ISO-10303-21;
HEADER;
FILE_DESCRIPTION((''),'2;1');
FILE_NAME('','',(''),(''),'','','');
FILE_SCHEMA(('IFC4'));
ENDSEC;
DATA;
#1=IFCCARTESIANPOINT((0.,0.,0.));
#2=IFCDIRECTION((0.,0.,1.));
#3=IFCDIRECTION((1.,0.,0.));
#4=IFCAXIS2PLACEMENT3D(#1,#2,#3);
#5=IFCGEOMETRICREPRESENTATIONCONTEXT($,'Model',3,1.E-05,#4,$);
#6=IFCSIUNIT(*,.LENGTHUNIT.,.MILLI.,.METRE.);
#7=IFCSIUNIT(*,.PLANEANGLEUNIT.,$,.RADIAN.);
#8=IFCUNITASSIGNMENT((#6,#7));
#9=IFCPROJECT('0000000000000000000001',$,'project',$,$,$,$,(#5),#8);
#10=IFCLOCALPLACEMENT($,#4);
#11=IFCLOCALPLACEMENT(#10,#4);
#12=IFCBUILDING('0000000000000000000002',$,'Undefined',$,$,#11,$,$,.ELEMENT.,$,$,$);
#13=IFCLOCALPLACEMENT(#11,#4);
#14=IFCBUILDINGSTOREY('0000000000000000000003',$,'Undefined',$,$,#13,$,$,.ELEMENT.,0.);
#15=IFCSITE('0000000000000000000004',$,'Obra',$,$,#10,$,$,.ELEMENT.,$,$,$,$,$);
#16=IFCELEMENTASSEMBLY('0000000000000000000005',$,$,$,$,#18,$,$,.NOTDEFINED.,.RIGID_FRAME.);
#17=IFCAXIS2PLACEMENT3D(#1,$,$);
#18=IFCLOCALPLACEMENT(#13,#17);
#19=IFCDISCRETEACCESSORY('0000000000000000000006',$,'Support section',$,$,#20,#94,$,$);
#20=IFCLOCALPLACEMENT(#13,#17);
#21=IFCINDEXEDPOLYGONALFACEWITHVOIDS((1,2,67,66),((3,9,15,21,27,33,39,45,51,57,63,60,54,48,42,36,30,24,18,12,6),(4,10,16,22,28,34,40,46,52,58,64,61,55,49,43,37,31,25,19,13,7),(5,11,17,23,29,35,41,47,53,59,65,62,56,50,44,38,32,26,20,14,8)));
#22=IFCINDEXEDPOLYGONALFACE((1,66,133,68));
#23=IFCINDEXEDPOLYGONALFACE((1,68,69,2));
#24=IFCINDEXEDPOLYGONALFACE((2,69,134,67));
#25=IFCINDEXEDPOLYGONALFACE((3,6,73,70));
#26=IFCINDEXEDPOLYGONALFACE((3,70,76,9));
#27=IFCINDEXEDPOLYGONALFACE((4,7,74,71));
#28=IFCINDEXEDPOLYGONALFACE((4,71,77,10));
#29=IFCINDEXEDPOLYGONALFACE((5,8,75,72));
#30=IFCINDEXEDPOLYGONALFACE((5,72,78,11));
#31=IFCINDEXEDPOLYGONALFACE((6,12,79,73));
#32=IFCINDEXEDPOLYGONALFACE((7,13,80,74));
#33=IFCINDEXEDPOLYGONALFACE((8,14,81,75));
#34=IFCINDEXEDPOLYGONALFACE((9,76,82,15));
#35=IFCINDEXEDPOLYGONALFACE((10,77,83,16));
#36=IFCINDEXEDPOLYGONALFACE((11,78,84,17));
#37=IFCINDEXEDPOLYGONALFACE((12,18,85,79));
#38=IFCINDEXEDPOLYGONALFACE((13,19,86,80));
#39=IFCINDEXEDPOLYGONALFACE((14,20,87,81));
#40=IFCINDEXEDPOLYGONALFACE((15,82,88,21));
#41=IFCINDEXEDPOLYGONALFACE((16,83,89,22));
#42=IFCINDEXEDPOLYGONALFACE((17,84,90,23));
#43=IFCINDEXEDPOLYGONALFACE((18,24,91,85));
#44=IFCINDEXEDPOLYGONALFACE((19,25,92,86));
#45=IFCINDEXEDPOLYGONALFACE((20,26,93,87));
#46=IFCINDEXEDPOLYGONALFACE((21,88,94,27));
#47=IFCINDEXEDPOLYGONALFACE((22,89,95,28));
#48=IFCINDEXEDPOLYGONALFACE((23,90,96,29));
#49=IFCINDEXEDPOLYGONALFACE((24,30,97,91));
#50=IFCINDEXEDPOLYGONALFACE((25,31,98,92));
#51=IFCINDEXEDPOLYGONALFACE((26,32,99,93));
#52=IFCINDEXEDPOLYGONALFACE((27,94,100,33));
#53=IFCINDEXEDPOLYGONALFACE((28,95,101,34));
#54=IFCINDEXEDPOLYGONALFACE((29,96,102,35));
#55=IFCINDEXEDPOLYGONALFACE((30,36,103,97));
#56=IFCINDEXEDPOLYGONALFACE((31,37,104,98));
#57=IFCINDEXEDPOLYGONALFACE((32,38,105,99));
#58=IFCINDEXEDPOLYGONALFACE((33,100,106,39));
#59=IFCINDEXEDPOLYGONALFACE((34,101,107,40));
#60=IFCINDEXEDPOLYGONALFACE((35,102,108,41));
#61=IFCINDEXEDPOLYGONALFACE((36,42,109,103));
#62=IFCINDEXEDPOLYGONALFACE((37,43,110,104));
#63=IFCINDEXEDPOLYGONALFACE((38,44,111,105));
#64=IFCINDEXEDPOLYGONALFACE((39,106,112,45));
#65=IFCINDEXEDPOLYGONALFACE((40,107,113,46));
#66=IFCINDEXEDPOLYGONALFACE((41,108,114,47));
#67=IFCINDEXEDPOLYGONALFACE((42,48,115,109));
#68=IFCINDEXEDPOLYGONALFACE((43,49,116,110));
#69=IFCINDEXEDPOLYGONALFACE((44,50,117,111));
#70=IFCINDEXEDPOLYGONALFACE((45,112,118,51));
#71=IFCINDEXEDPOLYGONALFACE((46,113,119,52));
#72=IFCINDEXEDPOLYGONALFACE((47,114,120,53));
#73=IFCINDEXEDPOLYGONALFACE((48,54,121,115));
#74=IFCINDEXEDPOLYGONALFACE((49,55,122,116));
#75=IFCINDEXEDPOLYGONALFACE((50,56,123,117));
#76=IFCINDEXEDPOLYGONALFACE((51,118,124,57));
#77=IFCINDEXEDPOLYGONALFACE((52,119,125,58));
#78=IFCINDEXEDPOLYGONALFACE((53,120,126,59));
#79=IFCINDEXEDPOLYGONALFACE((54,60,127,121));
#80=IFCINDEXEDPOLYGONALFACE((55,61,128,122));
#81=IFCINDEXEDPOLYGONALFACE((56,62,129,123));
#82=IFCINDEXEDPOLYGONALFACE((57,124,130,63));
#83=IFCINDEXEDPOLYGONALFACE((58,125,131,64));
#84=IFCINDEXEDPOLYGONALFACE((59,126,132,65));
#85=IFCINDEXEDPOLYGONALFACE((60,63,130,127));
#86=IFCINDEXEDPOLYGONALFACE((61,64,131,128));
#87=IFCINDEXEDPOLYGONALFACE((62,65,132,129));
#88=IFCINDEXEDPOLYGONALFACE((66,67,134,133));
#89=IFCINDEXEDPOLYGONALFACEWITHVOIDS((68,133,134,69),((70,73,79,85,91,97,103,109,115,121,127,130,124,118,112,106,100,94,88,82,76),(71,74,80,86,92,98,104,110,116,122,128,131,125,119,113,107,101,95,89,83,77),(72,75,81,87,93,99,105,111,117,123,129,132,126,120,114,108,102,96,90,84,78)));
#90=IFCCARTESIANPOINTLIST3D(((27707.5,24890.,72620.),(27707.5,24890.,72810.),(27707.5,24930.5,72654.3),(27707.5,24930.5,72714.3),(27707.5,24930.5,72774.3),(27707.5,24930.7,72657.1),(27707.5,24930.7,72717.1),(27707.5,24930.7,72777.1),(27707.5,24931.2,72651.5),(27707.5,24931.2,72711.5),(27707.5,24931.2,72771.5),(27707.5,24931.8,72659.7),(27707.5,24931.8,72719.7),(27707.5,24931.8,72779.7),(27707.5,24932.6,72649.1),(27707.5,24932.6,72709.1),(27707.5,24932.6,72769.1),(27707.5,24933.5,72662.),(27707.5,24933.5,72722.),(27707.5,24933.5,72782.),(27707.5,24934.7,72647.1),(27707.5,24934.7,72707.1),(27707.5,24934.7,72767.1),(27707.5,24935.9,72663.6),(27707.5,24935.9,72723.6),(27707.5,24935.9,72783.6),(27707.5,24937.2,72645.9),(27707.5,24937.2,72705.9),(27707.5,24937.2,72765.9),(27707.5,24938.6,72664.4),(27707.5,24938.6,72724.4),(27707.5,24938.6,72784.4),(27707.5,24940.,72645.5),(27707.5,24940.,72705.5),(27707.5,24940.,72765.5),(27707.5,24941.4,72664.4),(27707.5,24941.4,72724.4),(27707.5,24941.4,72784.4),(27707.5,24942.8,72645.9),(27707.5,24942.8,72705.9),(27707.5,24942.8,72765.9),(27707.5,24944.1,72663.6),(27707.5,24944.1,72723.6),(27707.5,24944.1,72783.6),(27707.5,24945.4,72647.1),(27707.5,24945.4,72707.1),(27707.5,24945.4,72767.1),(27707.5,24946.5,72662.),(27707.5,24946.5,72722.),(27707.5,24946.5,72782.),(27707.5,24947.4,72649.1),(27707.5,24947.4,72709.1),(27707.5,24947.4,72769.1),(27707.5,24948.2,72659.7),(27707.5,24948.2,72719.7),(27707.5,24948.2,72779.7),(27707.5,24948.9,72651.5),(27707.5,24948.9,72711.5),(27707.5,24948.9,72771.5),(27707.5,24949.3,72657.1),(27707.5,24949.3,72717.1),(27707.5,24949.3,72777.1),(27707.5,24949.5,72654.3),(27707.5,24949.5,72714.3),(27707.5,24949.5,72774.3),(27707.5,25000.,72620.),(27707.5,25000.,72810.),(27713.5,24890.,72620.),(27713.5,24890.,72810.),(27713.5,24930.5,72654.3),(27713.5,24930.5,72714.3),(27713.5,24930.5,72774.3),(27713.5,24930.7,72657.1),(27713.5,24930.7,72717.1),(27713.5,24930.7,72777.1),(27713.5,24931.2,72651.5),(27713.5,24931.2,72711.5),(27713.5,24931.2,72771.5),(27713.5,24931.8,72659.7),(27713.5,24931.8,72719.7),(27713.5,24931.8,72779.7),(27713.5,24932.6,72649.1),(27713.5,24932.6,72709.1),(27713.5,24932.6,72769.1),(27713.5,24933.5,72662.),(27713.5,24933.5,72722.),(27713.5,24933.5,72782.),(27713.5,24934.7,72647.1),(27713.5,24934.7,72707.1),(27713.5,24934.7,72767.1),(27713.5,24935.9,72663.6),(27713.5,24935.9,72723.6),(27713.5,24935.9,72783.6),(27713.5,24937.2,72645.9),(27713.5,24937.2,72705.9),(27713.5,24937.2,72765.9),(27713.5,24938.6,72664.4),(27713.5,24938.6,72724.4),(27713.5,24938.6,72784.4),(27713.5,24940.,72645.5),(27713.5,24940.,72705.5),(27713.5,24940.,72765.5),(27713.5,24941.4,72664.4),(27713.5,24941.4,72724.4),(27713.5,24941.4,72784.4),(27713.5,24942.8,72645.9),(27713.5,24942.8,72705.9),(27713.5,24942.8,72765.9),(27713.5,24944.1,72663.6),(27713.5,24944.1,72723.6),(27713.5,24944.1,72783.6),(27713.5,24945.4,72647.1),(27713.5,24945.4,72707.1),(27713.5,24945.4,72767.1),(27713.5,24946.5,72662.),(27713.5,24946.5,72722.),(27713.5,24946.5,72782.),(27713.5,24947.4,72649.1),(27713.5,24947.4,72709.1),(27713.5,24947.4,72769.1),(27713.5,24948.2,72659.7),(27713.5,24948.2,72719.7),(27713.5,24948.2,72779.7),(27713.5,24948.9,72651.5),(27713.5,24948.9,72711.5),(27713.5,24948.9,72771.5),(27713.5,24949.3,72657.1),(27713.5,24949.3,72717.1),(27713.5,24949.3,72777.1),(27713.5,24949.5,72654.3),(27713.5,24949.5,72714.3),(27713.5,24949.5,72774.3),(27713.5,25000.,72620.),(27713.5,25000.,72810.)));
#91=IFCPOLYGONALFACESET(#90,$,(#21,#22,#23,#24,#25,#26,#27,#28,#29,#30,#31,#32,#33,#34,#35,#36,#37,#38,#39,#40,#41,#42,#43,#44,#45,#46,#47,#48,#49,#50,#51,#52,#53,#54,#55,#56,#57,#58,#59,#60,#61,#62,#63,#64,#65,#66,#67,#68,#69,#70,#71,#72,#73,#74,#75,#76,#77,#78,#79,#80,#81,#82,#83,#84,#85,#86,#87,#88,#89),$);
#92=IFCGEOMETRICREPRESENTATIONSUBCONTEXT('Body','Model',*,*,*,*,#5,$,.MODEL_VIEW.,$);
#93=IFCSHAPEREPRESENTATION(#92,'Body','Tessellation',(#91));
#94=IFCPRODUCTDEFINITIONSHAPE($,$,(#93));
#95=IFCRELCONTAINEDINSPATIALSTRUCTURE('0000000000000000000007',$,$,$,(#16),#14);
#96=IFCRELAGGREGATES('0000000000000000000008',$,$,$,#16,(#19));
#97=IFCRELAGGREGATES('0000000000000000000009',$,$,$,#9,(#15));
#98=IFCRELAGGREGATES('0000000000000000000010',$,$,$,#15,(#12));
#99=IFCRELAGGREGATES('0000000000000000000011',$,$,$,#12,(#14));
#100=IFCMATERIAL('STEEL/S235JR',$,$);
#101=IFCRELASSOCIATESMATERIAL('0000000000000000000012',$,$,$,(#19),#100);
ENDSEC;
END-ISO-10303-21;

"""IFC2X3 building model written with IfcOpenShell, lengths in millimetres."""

from ifc_helpers import new_model, si_unit, frame, origin_with_axes, origin_2d_with_axis, place, context, subcontext, project, spatial, rectangle, circle, extrude, source, transform, mapped, material, element, aggregate, save


model = new_model("IFC2X3")

# Units and contexts
model_context = context("Model", 3, precision=1e-05, world=origin_with_axes())
body_context = subcontext(model_context, "Body", "Model", "MODEL_VIEW")
ifc_project = project(units=[si_unit("LENGTHUNIT", "METRE", prefix="MILLI"), si_unit("PLANEANGLEUNIT", "RADIAN")], contexts=[model_context])

# Site, building, storey
site_placement = place(None, origin_with_axes())
site = spatial("IfcSite", under=ifc_project, at=site_placement, Name="Obra", CompositionType="ELEMENT")
building_placement = place(site_placement, origin_with_axes())
building = spatial("IfcBuilding", under=site, at=building_placement, Name="Undefined", CompositionType="ELEMENT")
storey_placement = place(building_placement, origin_with_axes())
storey = spatial("IfcBuildingStorey", under=building, at=storey_placement, Name="Undefined", CompositionType="ELEMENT", Elevation=0.0)

# Element assembly
ifc_material_1 = material(Name="STEEL/S235JR")
assembly_1_placement = place(storey_placement, origin_with_axes())
assembly_1 = element("IfcElementAssembly", 1, at=assembly_1_placement, inside=storey, AssemblyPlace="NOTDEFINED", PredefinedType="RIGID_FRAME")

# Shared definitions
shared_shape_1 = source(origin_with_axes(), body_context, "Body", "SweptSolid", [
    extrude(circle(Radius=9.5, at=origin_2d_with_axis()), frame((0.0, -9.2, 0.0), z_axis=(0.0, 1.0, 0.0), x_axis=(1.0, 0.0, 0.0)), (0.0, 0.0, 1.0), 6.2),
])

# Discrete accessory, opening
discrete_accessory_1_placement = place(assembly_1_placement, frame((27710.5, 24945.0, 72620.0), z_axis=(0.0, 0.0, 1.0), x_axis=(-0.000002, 1.0, 0.0)))
discrete_accessory_1 = element("IfcDiscreteAccessory", 2, at=discrete_accessory_1_placement, material=ifc_material_1, Name="Support section", context=body_context, shape_type="SweptSolid", body=[
    extrude(rectangle(XDim=6.0, YDim=110.0, at=origin_2d_with_axis()), frame((0.0, 0.0, 190.0), z_axis=(0.0, 0.0, -1.0), x_axis=(0.0, 1.0, 0.0)), (0.0, 0.0, 1.0), 190.0),
])
opening_1_placement = place(assembly_1_placement, frame((27716.6, 24990.0, 72835.0), z_axis=(0.000002, -1.0, 0.0), x_axis=(0.0, 0.0, -1.0)))
element("IfcOpeningElement", 3, at=opening_1_placement, cuts=discrete_accessory_1, ObjectType="Opening", context=body_context, shape_type="MappedRepresentation", body=[
    mapped(shared_shape_1, transform((60.0, 0.0, 50.0))),
    mapped(shared_shape_1, transform((120.0, 0.0, 50.0))),
    mapped(shared_shape_1, transform((180.0, 0.0, 50.0))),
])
aggregate(assembly_1, [discrete_accessory_1])

save(model, "model.ifc")
